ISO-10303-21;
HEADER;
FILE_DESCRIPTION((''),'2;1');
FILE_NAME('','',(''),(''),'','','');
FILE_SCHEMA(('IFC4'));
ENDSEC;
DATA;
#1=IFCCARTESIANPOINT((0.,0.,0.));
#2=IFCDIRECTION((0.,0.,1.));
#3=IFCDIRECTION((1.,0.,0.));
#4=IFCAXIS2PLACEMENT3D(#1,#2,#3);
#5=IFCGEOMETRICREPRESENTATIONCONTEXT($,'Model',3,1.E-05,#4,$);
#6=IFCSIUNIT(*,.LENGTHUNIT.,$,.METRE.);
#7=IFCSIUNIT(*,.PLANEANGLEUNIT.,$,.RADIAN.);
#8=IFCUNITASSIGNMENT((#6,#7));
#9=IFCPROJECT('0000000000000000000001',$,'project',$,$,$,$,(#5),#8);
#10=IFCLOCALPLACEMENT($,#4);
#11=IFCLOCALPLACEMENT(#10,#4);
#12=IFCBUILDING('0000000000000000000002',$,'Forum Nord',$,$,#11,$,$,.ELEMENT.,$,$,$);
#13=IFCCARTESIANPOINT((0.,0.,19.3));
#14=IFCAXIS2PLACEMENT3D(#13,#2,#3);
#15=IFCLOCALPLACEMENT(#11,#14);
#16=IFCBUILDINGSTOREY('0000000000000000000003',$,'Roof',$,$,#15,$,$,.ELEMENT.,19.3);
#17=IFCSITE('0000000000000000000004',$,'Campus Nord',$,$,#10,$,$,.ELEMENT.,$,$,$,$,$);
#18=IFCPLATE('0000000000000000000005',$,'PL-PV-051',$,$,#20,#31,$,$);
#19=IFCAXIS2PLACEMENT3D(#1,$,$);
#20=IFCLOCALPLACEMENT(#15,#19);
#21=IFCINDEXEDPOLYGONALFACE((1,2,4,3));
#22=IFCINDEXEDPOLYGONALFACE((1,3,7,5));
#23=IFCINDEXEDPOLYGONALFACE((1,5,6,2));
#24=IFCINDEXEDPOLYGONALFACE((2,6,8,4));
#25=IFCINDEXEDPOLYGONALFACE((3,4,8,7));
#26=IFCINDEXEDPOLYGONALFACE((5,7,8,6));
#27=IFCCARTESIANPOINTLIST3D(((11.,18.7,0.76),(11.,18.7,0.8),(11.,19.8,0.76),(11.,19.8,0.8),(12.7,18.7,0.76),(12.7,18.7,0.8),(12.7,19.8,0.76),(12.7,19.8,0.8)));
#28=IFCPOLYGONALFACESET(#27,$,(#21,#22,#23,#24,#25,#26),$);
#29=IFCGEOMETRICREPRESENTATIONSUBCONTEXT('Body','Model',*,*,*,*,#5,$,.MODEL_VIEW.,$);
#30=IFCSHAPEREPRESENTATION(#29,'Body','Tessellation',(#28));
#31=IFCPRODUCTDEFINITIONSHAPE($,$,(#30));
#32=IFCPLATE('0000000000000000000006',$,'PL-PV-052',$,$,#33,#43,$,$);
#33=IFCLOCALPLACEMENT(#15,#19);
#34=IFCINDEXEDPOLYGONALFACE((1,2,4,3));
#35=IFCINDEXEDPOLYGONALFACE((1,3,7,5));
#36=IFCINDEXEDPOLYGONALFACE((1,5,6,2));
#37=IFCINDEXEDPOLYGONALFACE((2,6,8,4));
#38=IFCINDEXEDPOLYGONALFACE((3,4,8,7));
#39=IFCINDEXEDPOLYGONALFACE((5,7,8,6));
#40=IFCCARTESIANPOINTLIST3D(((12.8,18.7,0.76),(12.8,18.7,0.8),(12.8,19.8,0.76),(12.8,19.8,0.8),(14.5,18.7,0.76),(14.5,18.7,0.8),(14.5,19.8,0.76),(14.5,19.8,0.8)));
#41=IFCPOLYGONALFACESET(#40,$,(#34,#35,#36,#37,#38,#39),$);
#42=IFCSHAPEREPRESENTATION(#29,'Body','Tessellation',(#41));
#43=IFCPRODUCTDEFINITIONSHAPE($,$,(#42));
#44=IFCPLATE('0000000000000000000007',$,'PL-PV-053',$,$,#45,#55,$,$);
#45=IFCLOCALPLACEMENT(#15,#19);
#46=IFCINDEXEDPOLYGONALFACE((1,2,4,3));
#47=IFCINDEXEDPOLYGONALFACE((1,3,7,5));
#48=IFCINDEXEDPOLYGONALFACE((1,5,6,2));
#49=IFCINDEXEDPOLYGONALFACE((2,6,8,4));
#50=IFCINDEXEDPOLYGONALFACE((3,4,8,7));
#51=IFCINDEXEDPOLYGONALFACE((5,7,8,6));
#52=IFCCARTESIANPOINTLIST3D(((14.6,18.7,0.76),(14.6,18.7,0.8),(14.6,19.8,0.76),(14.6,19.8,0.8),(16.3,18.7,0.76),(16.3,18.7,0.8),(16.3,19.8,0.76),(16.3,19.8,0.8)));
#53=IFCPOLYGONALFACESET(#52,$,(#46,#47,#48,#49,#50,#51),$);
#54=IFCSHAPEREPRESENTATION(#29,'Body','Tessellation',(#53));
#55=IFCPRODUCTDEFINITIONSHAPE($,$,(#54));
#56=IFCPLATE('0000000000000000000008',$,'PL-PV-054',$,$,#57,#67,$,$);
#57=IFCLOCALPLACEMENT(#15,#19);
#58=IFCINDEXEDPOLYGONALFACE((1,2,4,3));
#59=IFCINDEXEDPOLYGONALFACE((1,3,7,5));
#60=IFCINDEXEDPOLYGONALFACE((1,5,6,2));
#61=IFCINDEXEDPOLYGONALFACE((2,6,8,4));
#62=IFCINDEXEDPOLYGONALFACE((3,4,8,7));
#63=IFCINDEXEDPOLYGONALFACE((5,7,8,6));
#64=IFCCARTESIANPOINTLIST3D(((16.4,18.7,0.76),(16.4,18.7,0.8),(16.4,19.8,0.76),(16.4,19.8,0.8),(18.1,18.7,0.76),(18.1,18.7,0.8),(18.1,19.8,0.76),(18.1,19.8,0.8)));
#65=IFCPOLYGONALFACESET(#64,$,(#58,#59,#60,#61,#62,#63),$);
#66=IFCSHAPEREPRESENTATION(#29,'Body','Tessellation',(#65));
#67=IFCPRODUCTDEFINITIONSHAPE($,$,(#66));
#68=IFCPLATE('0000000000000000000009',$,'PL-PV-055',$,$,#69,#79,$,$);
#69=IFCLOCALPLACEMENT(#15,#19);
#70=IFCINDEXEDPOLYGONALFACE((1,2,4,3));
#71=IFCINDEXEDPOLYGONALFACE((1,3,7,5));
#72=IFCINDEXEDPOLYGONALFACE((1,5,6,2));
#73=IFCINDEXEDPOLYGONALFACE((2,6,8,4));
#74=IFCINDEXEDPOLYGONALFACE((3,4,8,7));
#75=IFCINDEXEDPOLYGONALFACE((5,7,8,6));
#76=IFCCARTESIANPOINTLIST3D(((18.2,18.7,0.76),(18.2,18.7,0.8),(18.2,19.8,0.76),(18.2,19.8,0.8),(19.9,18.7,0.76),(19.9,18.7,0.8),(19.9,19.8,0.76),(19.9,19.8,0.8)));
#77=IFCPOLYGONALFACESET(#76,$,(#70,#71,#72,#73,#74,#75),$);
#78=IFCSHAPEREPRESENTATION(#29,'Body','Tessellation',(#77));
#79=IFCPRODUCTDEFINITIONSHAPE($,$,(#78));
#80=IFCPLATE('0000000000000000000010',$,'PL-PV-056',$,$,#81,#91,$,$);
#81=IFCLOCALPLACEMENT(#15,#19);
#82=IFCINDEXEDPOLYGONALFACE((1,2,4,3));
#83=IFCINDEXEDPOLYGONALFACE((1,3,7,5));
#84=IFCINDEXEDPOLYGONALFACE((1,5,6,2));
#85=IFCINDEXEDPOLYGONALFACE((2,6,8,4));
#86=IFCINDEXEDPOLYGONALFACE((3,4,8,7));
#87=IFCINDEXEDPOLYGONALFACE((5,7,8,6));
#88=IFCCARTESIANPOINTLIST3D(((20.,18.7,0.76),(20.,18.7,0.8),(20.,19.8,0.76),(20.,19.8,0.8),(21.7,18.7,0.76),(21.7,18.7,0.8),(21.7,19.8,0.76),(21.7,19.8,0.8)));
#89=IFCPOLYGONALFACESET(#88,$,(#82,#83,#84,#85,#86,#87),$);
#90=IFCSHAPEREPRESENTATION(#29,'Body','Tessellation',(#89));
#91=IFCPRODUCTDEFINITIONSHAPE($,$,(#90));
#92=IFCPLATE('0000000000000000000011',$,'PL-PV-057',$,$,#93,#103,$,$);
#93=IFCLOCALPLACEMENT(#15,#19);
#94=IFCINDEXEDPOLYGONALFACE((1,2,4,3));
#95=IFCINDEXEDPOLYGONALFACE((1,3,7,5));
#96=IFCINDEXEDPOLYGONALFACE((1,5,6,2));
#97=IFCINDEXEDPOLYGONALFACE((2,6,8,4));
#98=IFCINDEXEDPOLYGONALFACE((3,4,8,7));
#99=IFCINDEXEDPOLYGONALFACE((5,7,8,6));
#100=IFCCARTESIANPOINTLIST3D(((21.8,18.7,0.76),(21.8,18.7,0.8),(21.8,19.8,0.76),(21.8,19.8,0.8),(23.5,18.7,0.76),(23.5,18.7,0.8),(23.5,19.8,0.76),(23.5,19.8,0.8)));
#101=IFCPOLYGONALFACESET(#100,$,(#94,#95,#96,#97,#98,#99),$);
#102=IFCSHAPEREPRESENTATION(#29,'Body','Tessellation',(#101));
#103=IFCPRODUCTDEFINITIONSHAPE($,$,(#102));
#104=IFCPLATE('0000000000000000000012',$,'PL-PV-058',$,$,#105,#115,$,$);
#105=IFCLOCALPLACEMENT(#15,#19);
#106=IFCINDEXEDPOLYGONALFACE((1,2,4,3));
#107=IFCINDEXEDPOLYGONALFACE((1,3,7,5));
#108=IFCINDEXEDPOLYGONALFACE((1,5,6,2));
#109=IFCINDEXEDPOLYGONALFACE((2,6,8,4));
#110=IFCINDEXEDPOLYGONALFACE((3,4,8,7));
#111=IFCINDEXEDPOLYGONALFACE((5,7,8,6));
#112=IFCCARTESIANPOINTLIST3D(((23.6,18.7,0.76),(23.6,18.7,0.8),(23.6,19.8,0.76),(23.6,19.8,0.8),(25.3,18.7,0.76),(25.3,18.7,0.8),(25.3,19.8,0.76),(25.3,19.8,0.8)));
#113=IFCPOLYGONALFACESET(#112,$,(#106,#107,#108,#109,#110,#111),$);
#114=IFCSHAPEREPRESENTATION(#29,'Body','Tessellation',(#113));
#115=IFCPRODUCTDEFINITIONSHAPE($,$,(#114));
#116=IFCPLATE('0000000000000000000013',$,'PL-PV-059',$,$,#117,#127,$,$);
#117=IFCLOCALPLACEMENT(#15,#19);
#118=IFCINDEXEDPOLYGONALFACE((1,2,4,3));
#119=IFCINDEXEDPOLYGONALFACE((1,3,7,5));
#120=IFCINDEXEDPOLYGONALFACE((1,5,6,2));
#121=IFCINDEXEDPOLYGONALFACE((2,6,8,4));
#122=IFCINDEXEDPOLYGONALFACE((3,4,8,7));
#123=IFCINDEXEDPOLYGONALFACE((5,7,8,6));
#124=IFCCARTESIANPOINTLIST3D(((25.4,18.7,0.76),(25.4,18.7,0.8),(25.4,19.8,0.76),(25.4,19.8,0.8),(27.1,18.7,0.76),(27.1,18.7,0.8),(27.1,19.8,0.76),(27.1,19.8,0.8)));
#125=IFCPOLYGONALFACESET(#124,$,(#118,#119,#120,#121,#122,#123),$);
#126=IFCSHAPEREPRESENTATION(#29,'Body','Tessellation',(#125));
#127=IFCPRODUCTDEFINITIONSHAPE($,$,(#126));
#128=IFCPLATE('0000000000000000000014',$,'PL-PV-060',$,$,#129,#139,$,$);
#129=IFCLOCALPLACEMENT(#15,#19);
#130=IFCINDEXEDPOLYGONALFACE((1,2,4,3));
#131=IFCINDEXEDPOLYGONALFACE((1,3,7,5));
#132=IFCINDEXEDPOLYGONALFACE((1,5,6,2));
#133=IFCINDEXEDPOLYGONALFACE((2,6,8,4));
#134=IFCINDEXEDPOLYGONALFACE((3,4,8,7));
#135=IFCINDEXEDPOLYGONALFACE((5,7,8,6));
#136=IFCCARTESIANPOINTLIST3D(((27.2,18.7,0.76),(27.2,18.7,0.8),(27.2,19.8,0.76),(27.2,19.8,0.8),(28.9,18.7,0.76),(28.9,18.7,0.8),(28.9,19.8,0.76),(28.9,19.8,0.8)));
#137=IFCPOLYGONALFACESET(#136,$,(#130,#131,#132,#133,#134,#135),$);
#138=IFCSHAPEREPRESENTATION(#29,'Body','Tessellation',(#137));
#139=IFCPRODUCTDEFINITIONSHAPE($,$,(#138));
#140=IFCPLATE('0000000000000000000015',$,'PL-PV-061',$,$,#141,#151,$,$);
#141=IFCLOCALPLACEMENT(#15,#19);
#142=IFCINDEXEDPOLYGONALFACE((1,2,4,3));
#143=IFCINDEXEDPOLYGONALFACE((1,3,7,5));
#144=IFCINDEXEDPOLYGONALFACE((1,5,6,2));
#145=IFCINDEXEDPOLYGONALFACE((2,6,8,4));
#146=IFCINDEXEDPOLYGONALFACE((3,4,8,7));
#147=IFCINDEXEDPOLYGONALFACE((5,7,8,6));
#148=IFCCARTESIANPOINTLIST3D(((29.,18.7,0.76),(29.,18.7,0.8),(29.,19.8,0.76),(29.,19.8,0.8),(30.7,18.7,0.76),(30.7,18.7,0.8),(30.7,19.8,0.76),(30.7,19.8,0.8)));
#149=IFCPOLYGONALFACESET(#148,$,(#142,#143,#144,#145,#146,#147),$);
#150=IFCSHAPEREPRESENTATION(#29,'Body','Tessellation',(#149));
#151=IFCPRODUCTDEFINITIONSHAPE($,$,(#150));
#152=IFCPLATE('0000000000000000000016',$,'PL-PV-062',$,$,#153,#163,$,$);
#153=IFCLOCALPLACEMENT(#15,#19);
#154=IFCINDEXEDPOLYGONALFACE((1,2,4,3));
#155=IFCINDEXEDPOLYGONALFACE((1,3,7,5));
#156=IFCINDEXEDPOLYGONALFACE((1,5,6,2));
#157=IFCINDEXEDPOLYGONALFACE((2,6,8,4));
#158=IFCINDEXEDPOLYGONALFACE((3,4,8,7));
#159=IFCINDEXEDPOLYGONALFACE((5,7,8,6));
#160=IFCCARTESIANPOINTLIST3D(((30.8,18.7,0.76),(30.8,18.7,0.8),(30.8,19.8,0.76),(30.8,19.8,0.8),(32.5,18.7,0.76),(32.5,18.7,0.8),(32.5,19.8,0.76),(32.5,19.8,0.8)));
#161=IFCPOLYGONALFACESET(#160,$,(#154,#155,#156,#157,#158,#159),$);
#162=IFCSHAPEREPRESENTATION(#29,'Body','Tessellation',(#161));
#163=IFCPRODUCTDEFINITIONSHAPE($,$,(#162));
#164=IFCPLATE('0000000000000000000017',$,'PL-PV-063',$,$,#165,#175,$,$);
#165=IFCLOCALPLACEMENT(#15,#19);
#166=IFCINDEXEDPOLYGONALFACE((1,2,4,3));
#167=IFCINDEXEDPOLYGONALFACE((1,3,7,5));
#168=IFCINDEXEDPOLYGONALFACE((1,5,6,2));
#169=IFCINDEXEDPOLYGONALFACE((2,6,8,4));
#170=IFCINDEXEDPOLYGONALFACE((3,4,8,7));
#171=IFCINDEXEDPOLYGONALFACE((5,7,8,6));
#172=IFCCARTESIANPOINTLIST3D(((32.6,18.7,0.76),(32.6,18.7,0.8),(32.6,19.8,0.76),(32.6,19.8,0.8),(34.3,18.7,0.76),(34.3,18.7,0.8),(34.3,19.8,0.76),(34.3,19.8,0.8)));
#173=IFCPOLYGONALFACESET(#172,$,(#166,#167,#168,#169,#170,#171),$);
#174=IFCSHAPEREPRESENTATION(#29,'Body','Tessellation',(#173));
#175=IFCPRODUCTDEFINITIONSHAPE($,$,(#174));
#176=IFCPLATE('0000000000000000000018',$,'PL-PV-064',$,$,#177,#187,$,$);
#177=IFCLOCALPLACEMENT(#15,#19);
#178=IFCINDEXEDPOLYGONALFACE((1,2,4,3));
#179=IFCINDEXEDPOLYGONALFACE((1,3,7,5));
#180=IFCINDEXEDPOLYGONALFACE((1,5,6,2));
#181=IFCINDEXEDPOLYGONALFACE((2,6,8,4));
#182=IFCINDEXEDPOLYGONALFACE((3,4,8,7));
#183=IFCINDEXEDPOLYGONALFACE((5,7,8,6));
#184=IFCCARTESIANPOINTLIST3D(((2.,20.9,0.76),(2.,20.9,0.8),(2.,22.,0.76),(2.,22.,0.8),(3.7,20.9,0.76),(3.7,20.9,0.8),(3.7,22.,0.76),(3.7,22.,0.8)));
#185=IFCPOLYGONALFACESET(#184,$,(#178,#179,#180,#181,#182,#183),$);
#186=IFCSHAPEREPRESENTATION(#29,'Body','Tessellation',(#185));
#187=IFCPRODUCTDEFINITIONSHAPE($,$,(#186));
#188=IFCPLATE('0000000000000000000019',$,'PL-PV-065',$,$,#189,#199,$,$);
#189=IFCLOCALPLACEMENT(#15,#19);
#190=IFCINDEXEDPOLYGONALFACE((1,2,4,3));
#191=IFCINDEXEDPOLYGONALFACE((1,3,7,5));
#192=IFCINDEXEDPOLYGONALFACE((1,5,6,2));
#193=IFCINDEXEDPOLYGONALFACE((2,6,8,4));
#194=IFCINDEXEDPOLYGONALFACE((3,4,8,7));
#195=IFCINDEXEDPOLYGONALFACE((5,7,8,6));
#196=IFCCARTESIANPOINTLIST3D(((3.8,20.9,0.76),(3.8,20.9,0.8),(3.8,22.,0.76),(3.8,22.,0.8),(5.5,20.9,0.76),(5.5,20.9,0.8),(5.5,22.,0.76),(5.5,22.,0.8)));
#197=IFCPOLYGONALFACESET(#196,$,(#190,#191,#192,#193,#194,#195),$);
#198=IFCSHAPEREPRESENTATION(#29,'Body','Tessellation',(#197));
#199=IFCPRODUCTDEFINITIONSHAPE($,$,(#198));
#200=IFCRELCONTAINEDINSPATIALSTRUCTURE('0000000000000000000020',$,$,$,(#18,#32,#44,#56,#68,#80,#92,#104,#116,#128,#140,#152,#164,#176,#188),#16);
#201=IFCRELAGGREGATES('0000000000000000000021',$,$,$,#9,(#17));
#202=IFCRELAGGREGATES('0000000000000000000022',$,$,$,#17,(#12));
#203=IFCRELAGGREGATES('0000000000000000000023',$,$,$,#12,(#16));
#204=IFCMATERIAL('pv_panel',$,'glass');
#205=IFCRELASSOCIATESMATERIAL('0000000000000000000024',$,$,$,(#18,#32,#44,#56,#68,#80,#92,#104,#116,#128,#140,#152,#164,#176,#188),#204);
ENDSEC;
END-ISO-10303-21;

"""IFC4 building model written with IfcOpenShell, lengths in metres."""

from ifc_helpers import new_model, si_unit, frame, origin_with_axes, place, context, subcontext, project, spatial, polyline, outline, extrude, material, element, save


model = new_model("IFC4")

# Units and contexts
model_context = context("Model", 3, precision=1e-05, world=origin_with_axes())
body_context = subcontext(model_context, "Body", "Model", "MODEL_VIEW")
ifc_project = project(units=[si_unit("LENGTHUNIT", "METRE"), si_unit("PLANEANGLEUNIT", "RADIAN")], contexts=[model_context])

# Site, building, storey
site_placement = place(None, origin_with_axes())
site = spatial("IfcSite", under=ifc_project, at=site_placement, Name="Campus Nord", CompositionType="ELEMENT")
building_placement = place(site_placement, origin_with_axes())
building = spatial("IfcBuilding", under=site, at=building_placement, Name="Forum Nord", CompositionType="ELEMENT")
storey_placement = place(building_placement, frame((0.0, 0.0, 19.3), z_axis=(0.0, 0.0, 1.0), x_axis=(1.0, 0.0, 0.0)))
storey = spatial("IfcBuildingStorey", under=building, at=storey_placement, Name="Roof", CompositionType="ELEMENT", Elevation=19.3)

# Plates
ifc_material = material(Name="pv_panel", Category="glass")
plate_1_placement = place(storey_placement, frame((0.0, 0.0, 0.8), z_axis=(0.0, 0.0, 1.0), x_axis=(1.0, 0.0, 0.0)))
element("IfcPlate", 1, at=plate_1_placement, inside=storey, material=ifc_material, Name="PL-PV-051", context=body_context, shape_type="SweptSolid", body=[
    extrude(outline(polyline([(11.0, 18.7), (12.7, 18.7), (12.7, 19.8), (11.0, 19.8), (11.0, 18.7)])), frame((0.0, 0.0, -0.04), z_axis=(0.0, 0.0, 1.0), x_axis=(1.0, 0.0, 0.0)), (0.0, 0.0, 1.0), 0.04),
])
plate_2_placement = place(storey_placement, frame((0.0, 0.0, 0.8), z_axis=(0.0, 0.0, 1.0), x_axis=(1.0, 0.0, 0.0)))
element("IfcPlate", 2, at=plate_2_placement, inside=storey, material=ifc_material, Name="PL-PV-052", context=body_context, shape_type="SweptSolid", body=[
    extrude(outline(polyline([(12.8, 18.7), (14.5, 18.7), (14.5, 19.8), (12.8, 19.8), (12.8, 18.7)])), frame((0.0, 0.0, -0.04), z_axis=(0.0, 0.0, 1.0), x_axis=(1.0, 0.0, 0.0)), (0.0, 0.0, 1.0), 0.04),
])
plate_3_placement = place(storey_placement, frame((0.0, 0.0, 0.8), z_axis=(0.0, 0.0, 1.0), x_axis=(1.0, 0.0, 0.0)))
element("IfcPlate", 3, at=plate_3_placement, inside=storey, material=ifc_material, Name="PL-PV-053", context=body_context, shape_type="SweptSolid", body=[
    extrude(outline(polyline([(14.6, 18.7), (16.3, 18.7), (16.3, 19.8), (14.6, 19.8), (14.6, 18.7)])), frame((0.0, 0.0, -0.04), z_axis=(0.0, 0.0, 1.0), x_axis=(1.0, 0.0, 0.0)), (0.0, 0.0, 1.0), 0.04),
])
plate_4_placement = place(storey_placement, frame((0.0, 0.0, 0.8), z_axis=(0.0, 0.0, 1.0), x_axis=(1.0, 0.0, 0.0)))
element("IfcPlate", 4, at=plate_4_placement, inside=storey, material=ifc_material, Name="PL-PV-054", context=body_context, shape_type="SweptSolid", body=[
    extrude(outline(polyline([(16.4, 18.7), (18.1, 18.7), (18.1, 19.8), (16.4, 19.8), (16.4, 18.7)])), frame((0.0, 0.0, -0.04), z_axis=(0.0, 0.0, 1.0), x_axis=(1.0, 0.0, 0.0)), (0.0, 0.0, 1.0), 0.04),
])
plate_5_placement = place(storey_placement, frame((0.0, 0.0, 0.8), z_axis=(0.0, 0.0, 1.0), x_axis=(1.0, 0.0, 0.0)))
element("IfcPlate", 5, at=plate_5_placement, inside=storey, material=ifc_material, Name="PL-PV-055", context=body_context, shape_type="SweptSolid", body=[
    extrude(outline(polyline([(18.2, 18.7), (19.9, 18.7), (19.9, 19.8), (18.2, 19.8), (18.2, 18.7)])), frame((0.0, 0.0, -0.04), z_axis=(0.0, 0.0, 1.0), x_axis=(1.0, 0.0, 0.0)), (0.0, 0.0, 1.0), 0.04),
])
plate_6_placement = place(storey_placement, frame((0.0, 0.0, 0.8), z_axis=(0.0, 0.0, 1.0), x_axis=(1.0, 0.0, 0.0)))
element("IfcPlate", 6, at=plate_6_placement, inside=storey, material=ifc_material, Name="PL-PV-056", context=body_context, shape_type="SweptSolid", body=[
    extrude(outline(polyline([(20.0, 18.7), (21.7, 18.7), (21.7, 19.8), (20.0, 19.8), (20.0, 18.7)])), frame((0.0, 0.0, -0.04), z_axis=(0.0, 0.0, 1.0), x_axis=(1.0, 0.0, 0.0)), (0.0, 0.0, 1.0), 0.04),
])
plate_7_placement = place(storey_placement, frame((0.0, 0.0, 0.8), z_axis=(0.0, 0.0, 1.0), x_axis=(1.0, 0.0, 0.0)))
element("IfcPlate", 7, at=plate_7_placement, inside=storey, material=ifc_material, Name="PL-PV-057", context=body_context, shape_type="SweptSolid", body=[
    extrude(outline(polyline([(21.8, 18.7), (23.5, 18.7), (23.5, 19.8), (21.8, 19.8), (21.8, 18.7)])), frame((0.0, 0.0, -0.04), z_axis=(0.0, 0.0, 1.0), x_axis=(1.0, 0.0, 0.0)), (0.0, 0.0, 1.0), 0.04),
])
plate_8_placement = place(storey_placement, frame((0.0, 0.0, 0.8), z_axis=(0.0, 0.0, 1.0), x_axis=(1.0, 0.0, 0.0)))
element("IfcPlate", 8, at=plate_8_placement, inside=storey, material=ifc_material, Name="PL-PV-058", context=body_context, shape_type="SweptSolid", body=[
    extrude(outline(polyline([(23.6, 18.7), (25.3, 18.7), (25.3, 19.8), (23.6, 19.8), (23.6, 18.7)])), frame((0.0, 0.0, -0.04), z_axis=(0.0, 0.0, 1.0), x_axis=(1.0, 0.0, 0.0)), (0.0, 0.0, 1.0), 0.04),
])
plate_9_placement = place(storey_placement, frame((0.0, 0.0, 0.8), z_axis=(0.0, 0.0, 1.0), x_axis=(1.0, 0.0, 0.0)))
element("IfcPlate", 9, at=plate_9_placement, inside=storey, material=ifc_material, Name="PL-PV-059", context=body_context, shape_type="SweptSolid", body=[
    extrude(outline(polyline([(25.4, 18.7), (27.1, 18.7), (27.1, 19.8), (25.4, 19.8), (25.4, 18.7)])), frame((0.0, 0.0, -0.04), z_axis=(0.0, 0.0, 1.0), x_axis=(1.0, 0.0, 0.0)), (0.0, 0.0, 1.0), 0.04),
])
plate_10_placement = place(storey_placement, frame((0.0, 0.0, 0.8), z_axis=(0.0, 0.0, 1.0), x_axis=(1.0, 0.0, 0.0)))
element("IfcPlate", 10, at=plate_10_placement, inside=storey, material=ifc_material, Name="PL-PV-060", context=body_context, shape_type="SweptSolid", body=[
    extrude(outline(polyline([(27.2, 18.7), (28.9, 18.7), (28.9, 19.8), (27.2, 19.8), (27.2, 18.7)])), frame((0.0, 0.0, -0.04), z_axis=(0.0, 0.0, 1.0), x_axis=(1.0, 0.0, 0.0)), (0.0, 0.0, 1.0), 0.04),
])
plate_11_placement = place(storey_placement, frame((0.0, 0.0, 0.8), z_axis=(0.0, 0.0, 1.0), x_axis=(1.0, 0.0, 0.0)))
element("IfcPlate", 11, at=plate_11_placement, inside=storey, material=ifc_material, Name="PL-PV-061", context=body_context, shape_type="SweptSolid", body=[
    extrude(outline(polyline([(29.0, 18.7), (30.7, 18.7), (30.7, 19.8), (29.0, 19.8), (29.0, 18.7)])), frame((0.0, 0.0, -0.04), z_axis=(0.0, 0.0, 1.0), x_axis=(1.0, 0.0, 0.0)), (0.0, 0.0, 1.0), 0.04),
])
plate_12_placement = place(storey_placement, frame((0.0, 0.0, 0.8), z_axis=(0.0, 0.0, 1.0), x_axis=(1.0, 0.0, 0.0)))
element("IfcPlate", 12, at=plate_12_placement, inside=storey, material=ifc_material, Name="PL-PV-062", context=body_context, shape_type="SweptSolid", body=[
    extrude(outline(polyline([(30.8, 18.7), (32.5, 18.7), (32.5, 19.8), (30.8, 19.8), (30.8, 18.7)])), frame((0.0, 0.0, -0.04), z_axis=(0.0, 0.0, 1.0), x_axis=(1.0, 0.0, 0.0)), (0.0, 0.0, 1.0), 0.04),
])
plate_13_placement = place(storey_placement, frame((0.0, 0.0, 0.8), z_axis=(0.0, 0.0, 1.0), x_axis=(1.0, 0.0, 0.0)))
element("IfcPlate", 13, at=plate_13_placement, inside=storey, material=ifc_material, Name="PL-PV-063", context=body_context, shape_type="SweptSolid", body=[
    extrude(outline(polyline([(32.6, 18.7), (34.3, 18.7), (34.3, 19.8), (32.6, 19.8), (32.6, 18.7)])), frame((0.0, 0.0, -0.04), z_axis=(0.0, 0.0, 1.0), x_axis=(1.0, 0.0, 0.0)), (0.0, 0.0, 1.0), 0.04),
])
plate_14_placement = place(storey_placement, frame((0.0, 0.0, 0.8), z_axis=(0.0, 0.0, 1.0), x_axis=(1.0, 0.0, 0.0)))
element("IfcPlate", 14, at=plate_14_placement, inside=storey, material=ifc_material, Name="PL-PV-064", context=body_context, shape_type="SweptSolid", body=[
    extrude(outline(polyline([(2.0, 20.9), (3.7, 20.9), (3.7, 22.0), (2.0, 22.0), (2.0, 20.9)])), frame((0.0, 0.0, -0.04), z_axis=(0.0, 0.0, 1.0), x_axis=(1.0, 0.0, 0.0)), (0.0, 0.0, 1.0), 0.04),
])
plate_15_placement = place(storey_placement, frame((0.0, 0.0, 0.8), z_axis=(0.0, 0.0, 1.0), x_axis=(1.0, 0.0, 0.0)))
element("IfcPlate", 15, at=plate_15_placement, inside=storey, material=ifc_material, Name="PL-PV-065", context=body_context, shape_type="SweptSolid", body=[
    extrude(outline(polyline([(3.8, 20.9), (5.5, 20.9), (5.5, 22.0), (3.8, 22.0), (3.8, 20.9)])), frame((0.0, 0.0, -0.04), z_axis=(0.0, 0.0, 1.0), x_axis=(1.0, 0.0, 0.0)), (0.0, 0.0, 1.0), 0.04),
])

save(model, "model.ifc")
